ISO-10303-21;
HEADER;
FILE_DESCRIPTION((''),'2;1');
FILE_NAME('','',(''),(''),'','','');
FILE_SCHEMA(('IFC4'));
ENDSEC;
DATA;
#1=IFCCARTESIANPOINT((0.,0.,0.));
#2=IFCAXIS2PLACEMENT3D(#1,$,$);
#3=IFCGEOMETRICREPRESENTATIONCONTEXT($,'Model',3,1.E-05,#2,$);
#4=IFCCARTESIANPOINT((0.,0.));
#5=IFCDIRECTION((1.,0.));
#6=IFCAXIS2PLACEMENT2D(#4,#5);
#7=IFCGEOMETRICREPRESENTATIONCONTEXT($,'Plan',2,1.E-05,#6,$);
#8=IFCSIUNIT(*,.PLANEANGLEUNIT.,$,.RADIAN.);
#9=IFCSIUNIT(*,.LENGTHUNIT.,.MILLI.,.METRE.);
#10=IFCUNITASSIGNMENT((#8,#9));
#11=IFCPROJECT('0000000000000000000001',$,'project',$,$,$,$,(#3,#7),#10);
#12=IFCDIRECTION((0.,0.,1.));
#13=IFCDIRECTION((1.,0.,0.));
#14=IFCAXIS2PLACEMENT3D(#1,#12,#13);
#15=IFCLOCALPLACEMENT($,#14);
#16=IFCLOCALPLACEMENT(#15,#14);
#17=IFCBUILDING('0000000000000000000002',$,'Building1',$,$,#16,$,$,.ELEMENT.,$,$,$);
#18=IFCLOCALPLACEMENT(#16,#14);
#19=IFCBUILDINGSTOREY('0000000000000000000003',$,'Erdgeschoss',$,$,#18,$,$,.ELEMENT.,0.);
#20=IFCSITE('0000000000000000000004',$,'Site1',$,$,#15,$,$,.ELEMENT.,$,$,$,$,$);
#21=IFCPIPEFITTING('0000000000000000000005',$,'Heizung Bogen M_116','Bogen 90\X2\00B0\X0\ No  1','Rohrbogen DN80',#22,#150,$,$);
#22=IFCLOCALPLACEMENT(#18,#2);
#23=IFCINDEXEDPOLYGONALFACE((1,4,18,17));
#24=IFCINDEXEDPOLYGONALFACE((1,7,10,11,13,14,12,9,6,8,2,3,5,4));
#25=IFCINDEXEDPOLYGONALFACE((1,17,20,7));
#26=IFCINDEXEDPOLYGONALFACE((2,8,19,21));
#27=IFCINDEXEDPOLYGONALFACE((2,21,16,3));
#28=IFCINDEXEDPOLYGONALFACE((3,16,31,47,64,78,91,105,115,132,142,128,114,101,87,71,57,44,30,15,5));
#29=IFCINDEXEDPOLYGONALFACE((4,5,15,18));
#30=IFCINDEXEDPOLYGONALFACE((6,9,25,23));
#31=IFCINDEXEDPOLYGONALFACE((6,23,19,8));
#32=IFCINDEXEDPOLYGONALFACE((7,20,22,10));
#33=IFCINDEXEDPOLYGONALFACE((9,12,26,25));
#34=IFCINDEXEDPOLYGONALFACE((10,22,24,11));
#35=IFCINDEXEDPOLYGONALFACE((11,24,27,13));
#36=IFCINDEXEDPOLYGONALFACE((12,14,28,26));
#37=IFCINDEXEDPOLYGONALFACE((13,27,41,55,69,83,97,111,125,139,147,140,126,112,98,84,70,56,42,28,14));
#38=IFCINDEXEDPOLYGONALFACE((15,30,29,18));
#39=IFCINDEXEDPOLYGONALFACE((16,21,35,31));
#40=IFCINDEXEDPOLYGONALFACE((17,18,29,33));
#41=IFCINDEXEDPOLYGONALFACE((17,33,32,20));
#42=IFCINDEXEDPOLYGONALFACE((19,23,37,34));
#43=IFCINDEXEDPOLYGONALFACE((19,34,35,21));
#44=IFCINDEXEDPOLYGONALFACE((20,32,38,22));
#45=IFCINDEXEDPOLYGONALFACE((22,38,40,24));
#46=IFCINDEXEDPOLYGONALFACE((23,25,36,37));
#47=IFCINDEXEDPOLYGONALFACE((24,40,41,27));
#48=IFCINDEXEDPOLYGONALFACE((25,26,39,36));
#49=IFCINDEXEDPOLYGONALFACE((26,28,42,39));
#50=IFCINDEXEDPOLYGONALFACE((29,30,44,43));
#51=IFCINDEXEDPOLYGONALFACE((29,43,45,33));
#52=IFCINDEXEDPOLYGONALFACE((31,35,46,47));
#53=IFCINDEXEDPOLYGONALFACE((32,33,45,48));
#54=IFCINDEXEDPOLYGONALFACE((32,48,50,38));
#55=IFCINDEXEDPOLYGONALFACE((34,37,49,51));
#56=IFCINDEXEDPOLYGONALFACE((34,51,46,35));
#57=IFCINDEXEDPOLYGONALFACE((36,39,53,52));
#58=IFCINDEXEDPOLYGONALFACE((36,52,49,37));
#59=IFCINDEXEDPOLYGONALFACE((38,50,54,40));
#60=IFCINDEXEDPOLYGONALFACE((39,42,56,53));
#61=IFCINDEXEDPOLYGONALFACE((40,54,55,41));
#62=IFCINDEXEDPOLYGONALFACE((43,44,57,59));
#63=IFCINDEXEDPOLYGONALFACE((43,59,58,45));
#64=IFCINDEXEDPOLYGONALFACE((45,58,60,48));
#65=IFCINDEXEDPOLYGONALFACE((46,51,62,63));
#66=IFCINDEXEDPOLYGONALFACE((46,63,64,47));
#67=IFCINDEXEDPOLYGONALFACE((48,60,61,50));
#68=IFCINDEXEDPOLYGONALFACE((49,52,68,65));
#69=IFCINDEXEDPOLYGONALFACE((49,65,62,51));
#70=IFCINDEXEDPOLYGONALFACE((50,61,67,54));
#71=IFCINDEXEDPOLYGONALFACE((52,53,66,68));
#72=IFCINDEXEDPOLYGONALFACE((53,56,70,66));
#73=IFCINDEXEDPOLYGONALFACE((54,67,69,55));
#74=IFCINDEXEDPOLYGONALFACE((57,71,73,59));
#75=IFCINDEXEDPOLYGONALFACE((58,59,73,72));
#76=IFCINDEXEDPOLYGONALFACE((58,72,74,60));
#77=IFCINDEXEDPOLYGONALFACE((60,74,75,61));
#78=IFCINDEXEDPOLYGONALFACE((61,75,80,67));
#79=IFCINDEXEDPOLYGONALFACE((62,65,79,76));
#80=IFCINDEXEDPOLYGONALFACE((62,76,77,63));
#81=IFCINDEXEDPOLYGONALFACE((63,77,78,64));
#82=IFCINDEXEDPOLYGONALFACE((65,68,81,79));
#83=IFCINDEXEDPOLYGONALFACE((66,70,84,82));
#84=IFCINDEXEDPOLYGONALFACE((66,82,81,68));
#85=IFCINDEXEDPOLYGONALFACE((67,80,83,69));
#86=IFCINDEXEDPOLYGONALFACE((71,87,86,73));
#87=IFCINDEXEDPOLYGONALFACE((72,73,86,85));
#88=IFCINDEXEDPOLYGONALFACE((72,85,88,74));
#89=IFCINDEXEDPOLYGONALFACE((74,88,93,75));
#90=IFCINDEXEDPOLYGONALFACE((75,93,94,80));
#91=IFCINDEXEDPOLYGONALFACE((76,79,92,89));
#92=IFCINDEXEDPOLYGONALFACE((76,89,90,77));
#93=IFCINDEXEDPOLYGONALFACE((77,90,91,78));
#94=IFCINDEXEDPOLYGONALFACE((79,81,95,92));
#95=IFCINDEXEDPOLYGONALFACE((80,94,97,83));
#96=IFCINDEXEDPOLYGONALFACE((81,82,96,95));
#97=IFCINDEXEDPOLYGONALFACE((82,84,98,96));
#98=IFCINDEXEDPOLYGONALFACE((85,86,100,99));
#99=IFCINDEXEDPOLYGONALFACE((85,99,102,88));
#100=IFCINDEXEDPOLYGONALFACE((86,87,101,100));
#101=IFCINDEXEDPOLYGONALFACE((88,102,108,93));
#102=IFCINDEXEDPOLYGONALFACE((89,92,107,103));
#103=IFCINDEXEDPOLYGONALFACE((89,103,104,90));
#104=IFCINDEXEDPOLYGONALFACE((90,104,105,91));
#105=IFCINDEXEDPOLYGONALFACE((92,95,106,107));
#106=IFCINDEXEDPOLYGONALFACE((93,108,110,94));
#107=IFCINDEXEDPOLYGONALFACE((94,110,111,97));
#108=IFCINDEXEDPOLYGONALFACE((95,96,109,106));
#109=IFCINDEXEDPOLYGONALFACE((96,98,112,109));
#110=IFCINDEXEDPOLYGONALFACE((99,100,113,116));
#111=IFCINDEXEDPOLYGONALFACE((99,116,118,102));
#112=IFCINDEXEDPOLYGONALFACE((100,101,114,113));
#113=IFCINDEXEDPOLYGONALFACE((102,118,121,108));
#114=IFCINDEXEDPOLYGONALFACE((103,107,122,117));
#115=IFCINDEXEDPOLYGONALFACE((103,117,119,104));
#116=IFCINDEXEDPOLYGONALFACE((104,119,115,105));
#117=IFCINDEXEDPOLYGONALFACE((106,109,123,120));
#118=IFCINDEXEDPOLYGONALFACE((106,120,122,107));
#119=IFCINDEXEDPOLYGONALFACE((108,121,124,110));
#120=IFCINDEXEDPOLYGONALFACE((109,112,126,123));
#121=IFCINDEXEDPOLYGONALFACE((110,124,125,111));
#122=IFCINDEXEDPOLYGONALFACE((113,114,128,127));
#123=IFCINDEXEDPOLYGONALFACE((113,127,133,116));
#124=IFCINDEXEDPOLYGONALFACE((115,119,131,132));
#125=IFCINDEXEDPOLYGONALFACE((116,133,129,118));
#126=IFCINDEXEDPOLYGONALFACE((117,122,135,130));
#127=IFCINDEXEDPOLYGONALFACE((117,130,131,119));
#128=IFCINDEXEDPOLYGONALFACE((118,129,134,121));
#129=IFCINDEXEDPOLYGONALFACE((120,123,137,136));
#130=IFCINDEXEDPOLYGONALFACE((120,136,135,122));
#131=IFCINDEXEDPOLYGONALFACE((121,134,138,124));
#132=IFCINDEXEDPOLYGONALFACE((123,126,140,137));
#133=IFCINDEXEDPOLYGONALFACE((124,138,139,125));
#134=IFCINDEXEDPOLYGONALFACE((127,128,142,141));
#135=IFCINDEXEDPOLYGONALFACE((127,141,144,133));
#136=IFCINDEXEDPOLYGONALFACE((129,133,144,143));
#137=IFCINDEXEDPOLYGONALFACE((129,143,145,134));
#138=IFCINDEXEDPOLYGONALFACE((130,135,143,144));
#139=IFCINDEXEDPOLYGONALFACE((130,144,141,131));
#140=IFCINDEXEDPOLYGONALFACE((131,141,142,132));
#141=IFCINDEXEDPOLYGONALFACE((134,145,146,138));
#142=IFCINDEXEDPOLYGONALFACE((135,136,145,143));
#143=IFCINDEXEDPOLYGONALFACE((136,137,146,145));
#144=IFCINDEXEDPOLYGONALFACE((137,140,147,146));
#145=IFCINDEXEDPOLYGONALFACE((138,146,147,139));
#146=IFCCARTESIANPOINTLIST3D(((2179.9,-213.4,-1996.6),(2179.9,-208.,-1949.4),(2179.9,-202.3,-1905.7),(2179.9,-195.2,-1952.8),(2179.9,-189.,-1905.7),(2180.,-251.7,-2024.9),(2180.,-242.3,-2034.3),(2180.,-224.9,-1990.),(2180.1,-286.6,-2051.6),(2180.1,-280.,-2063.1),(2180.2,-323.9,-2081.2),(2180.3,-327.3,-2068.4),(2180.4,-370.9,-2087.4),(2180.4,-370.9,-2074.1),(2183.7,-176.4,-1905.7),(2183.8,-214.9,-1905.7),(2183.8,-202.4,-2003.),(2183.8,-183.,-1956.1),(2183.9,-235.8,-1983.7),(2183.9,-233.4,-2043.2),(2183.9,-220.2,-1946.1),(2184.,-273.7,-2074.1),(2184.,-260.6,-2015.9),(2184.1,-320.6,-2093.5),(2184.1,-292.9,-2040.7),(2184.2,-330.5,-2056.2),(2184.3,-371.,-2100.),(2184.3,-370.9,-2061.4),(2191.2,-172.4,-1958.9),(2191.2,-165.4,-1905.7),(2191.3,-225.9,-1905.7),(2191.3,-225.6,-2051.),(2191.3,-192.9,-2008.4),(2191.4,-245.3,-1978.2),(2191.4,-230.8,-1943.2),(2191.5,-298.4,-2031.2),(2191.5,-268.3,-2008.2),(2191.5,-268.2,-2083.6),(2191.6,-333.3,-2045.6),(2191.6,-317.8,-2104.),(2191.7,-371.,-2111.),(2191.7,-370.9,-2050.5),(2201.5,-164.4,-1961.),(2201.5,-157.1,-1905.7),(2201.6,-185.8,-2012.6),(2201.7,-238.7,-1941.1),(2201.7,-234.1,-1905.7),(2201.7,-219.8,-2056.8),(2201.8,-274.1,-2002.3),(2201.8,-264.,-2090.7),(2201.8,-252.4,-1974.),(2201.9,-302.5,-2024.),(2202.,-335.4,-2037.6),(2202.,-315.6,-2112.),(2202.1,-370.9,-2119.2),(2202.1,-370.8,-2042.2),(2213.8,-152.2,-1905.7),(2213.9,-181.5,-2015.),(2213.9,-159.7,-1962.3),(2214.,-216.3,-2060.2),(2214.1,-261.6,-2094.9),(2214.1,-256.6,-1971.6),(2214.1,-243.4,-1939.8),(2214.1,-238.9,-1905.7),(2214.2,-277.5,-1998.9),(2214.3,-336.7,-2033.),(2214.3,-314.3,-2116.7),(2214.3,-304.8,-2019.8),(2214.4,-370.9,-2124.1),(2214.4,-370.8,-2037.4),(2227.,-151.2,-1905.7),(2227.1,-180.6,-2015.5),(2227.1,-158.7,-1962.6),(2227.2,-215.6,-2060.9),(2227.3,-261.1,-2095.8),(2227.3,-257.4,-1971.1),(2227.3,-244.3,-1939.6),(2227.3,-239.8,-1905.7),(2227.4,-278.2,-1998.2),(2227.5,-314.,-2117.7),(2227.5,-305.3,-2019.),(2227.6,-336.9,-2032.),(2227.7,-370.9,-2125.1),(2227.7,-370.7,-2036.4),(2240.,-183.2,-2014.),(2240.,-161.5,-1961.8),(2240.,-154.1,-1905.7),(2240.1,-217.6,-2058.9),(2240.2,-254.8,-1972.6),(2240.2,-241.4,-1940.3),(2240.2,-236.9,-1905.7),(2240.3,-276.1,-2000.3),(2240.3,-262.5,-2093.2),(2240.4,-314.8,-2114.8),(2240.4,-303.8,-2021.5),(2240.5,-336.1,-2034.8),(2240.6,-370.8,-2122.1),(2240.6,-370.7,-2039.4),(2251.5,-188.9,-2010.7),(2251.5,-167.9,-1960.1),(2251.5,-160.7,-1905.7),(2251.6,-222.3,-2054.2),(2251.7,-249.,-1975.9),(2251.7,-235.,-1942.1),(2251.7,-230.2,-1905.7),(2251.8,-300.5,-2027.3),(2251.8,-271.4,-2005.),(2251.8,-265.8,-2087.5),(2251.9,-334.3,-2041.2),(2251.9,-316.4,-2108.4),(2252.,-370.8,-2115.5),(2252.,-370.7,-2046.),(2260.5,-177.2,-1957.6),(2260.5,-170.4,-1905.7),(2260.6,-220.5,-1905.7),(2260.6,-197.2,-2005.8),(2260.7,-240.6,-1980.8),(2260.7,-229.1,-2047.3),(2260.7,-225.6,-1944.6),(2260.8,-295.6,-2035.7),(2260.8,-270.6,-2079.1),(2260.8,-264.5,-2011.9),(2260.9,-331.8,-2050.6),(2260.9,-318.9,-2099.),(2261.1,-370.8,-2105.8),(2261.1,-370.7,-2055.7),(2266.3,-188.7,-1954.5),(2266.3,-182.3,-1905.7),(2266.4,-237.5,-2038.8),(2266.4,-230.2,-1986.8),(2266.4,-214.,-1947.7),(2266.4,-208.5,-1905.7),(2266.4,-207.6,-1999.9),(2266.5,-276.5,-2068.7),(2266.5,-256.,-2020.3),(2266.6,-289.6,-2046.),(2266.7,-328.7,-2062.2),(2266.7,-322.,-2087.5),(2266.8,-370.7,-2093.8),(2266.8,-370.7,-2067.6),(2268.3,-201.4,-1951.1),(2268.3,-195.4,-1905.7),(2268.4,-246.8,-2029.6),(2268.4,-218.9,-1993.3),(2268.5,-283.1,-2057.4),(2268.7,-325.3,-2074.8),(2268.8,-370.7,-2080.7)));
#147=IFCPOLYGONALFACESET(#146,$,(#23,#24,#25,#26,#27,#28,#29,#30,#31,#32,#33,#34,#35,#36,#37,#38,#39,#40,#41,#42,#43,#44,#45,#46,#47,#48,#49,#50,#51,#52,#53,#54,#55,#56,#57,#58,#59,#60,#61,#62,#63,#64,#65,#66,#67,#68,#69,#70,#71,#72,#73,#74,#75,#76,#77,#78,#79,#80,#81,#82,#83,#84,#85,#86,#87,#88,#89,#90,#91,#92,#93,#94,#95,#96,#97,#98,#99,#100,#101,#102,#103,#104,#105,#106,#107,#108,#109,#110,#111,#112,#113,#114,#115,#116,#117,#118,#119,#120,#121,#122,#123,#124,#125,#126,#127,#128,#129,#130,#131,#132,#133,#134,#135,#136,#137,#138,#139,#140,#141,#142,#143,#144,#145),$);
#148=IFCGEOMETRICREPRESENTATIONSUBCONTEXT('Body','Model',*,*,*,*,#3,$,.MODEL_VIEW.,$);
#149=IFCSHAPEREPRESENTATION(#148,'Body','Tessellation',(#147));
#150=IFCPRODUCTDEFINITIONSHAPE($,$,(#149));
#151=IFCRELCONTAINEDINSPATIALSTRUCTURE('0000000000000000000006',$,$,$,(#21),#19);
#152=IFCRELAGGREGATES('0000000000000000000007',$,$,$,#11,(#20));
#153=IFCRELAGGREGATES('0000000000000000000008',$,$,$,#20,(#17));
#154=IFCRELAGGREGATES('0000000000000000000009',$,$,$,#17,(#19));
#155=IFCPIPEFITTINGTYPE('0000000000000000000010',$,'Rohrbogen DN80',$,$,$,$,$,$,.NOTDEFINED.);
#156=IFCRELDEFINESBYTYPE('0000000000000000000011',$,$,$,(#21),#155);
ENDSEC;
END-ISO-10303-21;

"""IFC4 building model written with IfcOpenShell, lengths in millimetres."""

from ifc_helpers import new_model, entity, si_unit, frame, origin, origin_with_axes, origin_2d_with_axis, place, context, subcontext, project, spatial, source, transform, mapped, type_object, element, save


model = new_model("IFC4")

# Units and contexts
model_context = context("Model", 3, precision=1e-05, world=origin())
plan_context = context("Plan", 2, precision=1e-05, world=origin_2d_with_axis())
body_context = subcontext(model_context, "Body", "Model", "MODEL_VIEW")
ifc_project = project(units=[si_unit("PLANEANGLEUNIT", "RADIAN"), si_unit("LENGTHUNIT", "METRE", prefix="MILLI")], contexts=[model_context, plan_context])

# Site, building, storey
site_placement = place(None, origin_with_axes())
site = spatial("IfcSite", under=ifc_project, at=site_placement, Name="Site1", CompositionType="ELEMENT")
building_placement = place(site_placement, origin_with_axes())
building = spatial("IfcBuilding", under=site, at=building_placement, Name="Building1", CompositionType="ELEMENT")
storey_placement = place(building_placement, origin_with_axes())
storey = spatial("IfcBuildingStorey", under=building, at=storey_placement, Name="Erdgeschoss", CompositionType="ELEMENT", Elevation=0.0)

# Pipe fitting
pipe_fitting_type_1 = type_object("IfcPipeFittingType", Name="Rohrbogen DN80", PredefinedType="NOTDEFINED")
ifc_direction_1 = entity("IfcDirection", [-1.0, 0.0, 0.0])
shared_shape_1 = source(origin_with_axes(), body_context, "Body", "SolidModel", [
    entity("IfcRevolvedAreaSolid", entity("IfcCircleProfileDef", "AREA", None, entity("IfcAxis2Placement2D", entity("IfcCartesianPoint", [0.0, 0.0]), entity("IfcDirection", [1.0, 0.0])), 44.5), entity("IfcAxis2Placement3D", entity("IfcCartesianPoint", [109.7, -0.2, 65.5]), ifc_direction_1, entity("IfcDirection", [0.0, 0.999996, 0.002779])), entity("IfcAxis1Placement", entity("IfcCartesianPoint", [0.0, 175.0, 0.0]), ifc_direction_1), 1.572437),
])
pipe_fitting_1_placement = place(storey_placement, frame((2224.0, -261.0, -2015.5), z_axis=(0.0, 0.0, 1.0), x_axis=(1.0, 0.0, 0.0)))
element("IfcPipeFitting", 1, at=pipe_fitting_1_placement, inside=storey, type_object=pipe_fitting_type_1, Name="Heizung Bogen M_116", Description="Bogen 90° No  1", ObjectType="Rohrbogen DN80", context=body_context, shape_type="MappedRepresentation", body=[
    mapped(shared_shape_1, transform((0.0, 0.0, 0.0), x_axis=(0.0, 0.0, 1.0), y_axis=(1.0, 0.0, 0.0), z_axis=(0.0, 1.0, 0.0), scale=1.0)),
])

save(model, "model.ifc")
